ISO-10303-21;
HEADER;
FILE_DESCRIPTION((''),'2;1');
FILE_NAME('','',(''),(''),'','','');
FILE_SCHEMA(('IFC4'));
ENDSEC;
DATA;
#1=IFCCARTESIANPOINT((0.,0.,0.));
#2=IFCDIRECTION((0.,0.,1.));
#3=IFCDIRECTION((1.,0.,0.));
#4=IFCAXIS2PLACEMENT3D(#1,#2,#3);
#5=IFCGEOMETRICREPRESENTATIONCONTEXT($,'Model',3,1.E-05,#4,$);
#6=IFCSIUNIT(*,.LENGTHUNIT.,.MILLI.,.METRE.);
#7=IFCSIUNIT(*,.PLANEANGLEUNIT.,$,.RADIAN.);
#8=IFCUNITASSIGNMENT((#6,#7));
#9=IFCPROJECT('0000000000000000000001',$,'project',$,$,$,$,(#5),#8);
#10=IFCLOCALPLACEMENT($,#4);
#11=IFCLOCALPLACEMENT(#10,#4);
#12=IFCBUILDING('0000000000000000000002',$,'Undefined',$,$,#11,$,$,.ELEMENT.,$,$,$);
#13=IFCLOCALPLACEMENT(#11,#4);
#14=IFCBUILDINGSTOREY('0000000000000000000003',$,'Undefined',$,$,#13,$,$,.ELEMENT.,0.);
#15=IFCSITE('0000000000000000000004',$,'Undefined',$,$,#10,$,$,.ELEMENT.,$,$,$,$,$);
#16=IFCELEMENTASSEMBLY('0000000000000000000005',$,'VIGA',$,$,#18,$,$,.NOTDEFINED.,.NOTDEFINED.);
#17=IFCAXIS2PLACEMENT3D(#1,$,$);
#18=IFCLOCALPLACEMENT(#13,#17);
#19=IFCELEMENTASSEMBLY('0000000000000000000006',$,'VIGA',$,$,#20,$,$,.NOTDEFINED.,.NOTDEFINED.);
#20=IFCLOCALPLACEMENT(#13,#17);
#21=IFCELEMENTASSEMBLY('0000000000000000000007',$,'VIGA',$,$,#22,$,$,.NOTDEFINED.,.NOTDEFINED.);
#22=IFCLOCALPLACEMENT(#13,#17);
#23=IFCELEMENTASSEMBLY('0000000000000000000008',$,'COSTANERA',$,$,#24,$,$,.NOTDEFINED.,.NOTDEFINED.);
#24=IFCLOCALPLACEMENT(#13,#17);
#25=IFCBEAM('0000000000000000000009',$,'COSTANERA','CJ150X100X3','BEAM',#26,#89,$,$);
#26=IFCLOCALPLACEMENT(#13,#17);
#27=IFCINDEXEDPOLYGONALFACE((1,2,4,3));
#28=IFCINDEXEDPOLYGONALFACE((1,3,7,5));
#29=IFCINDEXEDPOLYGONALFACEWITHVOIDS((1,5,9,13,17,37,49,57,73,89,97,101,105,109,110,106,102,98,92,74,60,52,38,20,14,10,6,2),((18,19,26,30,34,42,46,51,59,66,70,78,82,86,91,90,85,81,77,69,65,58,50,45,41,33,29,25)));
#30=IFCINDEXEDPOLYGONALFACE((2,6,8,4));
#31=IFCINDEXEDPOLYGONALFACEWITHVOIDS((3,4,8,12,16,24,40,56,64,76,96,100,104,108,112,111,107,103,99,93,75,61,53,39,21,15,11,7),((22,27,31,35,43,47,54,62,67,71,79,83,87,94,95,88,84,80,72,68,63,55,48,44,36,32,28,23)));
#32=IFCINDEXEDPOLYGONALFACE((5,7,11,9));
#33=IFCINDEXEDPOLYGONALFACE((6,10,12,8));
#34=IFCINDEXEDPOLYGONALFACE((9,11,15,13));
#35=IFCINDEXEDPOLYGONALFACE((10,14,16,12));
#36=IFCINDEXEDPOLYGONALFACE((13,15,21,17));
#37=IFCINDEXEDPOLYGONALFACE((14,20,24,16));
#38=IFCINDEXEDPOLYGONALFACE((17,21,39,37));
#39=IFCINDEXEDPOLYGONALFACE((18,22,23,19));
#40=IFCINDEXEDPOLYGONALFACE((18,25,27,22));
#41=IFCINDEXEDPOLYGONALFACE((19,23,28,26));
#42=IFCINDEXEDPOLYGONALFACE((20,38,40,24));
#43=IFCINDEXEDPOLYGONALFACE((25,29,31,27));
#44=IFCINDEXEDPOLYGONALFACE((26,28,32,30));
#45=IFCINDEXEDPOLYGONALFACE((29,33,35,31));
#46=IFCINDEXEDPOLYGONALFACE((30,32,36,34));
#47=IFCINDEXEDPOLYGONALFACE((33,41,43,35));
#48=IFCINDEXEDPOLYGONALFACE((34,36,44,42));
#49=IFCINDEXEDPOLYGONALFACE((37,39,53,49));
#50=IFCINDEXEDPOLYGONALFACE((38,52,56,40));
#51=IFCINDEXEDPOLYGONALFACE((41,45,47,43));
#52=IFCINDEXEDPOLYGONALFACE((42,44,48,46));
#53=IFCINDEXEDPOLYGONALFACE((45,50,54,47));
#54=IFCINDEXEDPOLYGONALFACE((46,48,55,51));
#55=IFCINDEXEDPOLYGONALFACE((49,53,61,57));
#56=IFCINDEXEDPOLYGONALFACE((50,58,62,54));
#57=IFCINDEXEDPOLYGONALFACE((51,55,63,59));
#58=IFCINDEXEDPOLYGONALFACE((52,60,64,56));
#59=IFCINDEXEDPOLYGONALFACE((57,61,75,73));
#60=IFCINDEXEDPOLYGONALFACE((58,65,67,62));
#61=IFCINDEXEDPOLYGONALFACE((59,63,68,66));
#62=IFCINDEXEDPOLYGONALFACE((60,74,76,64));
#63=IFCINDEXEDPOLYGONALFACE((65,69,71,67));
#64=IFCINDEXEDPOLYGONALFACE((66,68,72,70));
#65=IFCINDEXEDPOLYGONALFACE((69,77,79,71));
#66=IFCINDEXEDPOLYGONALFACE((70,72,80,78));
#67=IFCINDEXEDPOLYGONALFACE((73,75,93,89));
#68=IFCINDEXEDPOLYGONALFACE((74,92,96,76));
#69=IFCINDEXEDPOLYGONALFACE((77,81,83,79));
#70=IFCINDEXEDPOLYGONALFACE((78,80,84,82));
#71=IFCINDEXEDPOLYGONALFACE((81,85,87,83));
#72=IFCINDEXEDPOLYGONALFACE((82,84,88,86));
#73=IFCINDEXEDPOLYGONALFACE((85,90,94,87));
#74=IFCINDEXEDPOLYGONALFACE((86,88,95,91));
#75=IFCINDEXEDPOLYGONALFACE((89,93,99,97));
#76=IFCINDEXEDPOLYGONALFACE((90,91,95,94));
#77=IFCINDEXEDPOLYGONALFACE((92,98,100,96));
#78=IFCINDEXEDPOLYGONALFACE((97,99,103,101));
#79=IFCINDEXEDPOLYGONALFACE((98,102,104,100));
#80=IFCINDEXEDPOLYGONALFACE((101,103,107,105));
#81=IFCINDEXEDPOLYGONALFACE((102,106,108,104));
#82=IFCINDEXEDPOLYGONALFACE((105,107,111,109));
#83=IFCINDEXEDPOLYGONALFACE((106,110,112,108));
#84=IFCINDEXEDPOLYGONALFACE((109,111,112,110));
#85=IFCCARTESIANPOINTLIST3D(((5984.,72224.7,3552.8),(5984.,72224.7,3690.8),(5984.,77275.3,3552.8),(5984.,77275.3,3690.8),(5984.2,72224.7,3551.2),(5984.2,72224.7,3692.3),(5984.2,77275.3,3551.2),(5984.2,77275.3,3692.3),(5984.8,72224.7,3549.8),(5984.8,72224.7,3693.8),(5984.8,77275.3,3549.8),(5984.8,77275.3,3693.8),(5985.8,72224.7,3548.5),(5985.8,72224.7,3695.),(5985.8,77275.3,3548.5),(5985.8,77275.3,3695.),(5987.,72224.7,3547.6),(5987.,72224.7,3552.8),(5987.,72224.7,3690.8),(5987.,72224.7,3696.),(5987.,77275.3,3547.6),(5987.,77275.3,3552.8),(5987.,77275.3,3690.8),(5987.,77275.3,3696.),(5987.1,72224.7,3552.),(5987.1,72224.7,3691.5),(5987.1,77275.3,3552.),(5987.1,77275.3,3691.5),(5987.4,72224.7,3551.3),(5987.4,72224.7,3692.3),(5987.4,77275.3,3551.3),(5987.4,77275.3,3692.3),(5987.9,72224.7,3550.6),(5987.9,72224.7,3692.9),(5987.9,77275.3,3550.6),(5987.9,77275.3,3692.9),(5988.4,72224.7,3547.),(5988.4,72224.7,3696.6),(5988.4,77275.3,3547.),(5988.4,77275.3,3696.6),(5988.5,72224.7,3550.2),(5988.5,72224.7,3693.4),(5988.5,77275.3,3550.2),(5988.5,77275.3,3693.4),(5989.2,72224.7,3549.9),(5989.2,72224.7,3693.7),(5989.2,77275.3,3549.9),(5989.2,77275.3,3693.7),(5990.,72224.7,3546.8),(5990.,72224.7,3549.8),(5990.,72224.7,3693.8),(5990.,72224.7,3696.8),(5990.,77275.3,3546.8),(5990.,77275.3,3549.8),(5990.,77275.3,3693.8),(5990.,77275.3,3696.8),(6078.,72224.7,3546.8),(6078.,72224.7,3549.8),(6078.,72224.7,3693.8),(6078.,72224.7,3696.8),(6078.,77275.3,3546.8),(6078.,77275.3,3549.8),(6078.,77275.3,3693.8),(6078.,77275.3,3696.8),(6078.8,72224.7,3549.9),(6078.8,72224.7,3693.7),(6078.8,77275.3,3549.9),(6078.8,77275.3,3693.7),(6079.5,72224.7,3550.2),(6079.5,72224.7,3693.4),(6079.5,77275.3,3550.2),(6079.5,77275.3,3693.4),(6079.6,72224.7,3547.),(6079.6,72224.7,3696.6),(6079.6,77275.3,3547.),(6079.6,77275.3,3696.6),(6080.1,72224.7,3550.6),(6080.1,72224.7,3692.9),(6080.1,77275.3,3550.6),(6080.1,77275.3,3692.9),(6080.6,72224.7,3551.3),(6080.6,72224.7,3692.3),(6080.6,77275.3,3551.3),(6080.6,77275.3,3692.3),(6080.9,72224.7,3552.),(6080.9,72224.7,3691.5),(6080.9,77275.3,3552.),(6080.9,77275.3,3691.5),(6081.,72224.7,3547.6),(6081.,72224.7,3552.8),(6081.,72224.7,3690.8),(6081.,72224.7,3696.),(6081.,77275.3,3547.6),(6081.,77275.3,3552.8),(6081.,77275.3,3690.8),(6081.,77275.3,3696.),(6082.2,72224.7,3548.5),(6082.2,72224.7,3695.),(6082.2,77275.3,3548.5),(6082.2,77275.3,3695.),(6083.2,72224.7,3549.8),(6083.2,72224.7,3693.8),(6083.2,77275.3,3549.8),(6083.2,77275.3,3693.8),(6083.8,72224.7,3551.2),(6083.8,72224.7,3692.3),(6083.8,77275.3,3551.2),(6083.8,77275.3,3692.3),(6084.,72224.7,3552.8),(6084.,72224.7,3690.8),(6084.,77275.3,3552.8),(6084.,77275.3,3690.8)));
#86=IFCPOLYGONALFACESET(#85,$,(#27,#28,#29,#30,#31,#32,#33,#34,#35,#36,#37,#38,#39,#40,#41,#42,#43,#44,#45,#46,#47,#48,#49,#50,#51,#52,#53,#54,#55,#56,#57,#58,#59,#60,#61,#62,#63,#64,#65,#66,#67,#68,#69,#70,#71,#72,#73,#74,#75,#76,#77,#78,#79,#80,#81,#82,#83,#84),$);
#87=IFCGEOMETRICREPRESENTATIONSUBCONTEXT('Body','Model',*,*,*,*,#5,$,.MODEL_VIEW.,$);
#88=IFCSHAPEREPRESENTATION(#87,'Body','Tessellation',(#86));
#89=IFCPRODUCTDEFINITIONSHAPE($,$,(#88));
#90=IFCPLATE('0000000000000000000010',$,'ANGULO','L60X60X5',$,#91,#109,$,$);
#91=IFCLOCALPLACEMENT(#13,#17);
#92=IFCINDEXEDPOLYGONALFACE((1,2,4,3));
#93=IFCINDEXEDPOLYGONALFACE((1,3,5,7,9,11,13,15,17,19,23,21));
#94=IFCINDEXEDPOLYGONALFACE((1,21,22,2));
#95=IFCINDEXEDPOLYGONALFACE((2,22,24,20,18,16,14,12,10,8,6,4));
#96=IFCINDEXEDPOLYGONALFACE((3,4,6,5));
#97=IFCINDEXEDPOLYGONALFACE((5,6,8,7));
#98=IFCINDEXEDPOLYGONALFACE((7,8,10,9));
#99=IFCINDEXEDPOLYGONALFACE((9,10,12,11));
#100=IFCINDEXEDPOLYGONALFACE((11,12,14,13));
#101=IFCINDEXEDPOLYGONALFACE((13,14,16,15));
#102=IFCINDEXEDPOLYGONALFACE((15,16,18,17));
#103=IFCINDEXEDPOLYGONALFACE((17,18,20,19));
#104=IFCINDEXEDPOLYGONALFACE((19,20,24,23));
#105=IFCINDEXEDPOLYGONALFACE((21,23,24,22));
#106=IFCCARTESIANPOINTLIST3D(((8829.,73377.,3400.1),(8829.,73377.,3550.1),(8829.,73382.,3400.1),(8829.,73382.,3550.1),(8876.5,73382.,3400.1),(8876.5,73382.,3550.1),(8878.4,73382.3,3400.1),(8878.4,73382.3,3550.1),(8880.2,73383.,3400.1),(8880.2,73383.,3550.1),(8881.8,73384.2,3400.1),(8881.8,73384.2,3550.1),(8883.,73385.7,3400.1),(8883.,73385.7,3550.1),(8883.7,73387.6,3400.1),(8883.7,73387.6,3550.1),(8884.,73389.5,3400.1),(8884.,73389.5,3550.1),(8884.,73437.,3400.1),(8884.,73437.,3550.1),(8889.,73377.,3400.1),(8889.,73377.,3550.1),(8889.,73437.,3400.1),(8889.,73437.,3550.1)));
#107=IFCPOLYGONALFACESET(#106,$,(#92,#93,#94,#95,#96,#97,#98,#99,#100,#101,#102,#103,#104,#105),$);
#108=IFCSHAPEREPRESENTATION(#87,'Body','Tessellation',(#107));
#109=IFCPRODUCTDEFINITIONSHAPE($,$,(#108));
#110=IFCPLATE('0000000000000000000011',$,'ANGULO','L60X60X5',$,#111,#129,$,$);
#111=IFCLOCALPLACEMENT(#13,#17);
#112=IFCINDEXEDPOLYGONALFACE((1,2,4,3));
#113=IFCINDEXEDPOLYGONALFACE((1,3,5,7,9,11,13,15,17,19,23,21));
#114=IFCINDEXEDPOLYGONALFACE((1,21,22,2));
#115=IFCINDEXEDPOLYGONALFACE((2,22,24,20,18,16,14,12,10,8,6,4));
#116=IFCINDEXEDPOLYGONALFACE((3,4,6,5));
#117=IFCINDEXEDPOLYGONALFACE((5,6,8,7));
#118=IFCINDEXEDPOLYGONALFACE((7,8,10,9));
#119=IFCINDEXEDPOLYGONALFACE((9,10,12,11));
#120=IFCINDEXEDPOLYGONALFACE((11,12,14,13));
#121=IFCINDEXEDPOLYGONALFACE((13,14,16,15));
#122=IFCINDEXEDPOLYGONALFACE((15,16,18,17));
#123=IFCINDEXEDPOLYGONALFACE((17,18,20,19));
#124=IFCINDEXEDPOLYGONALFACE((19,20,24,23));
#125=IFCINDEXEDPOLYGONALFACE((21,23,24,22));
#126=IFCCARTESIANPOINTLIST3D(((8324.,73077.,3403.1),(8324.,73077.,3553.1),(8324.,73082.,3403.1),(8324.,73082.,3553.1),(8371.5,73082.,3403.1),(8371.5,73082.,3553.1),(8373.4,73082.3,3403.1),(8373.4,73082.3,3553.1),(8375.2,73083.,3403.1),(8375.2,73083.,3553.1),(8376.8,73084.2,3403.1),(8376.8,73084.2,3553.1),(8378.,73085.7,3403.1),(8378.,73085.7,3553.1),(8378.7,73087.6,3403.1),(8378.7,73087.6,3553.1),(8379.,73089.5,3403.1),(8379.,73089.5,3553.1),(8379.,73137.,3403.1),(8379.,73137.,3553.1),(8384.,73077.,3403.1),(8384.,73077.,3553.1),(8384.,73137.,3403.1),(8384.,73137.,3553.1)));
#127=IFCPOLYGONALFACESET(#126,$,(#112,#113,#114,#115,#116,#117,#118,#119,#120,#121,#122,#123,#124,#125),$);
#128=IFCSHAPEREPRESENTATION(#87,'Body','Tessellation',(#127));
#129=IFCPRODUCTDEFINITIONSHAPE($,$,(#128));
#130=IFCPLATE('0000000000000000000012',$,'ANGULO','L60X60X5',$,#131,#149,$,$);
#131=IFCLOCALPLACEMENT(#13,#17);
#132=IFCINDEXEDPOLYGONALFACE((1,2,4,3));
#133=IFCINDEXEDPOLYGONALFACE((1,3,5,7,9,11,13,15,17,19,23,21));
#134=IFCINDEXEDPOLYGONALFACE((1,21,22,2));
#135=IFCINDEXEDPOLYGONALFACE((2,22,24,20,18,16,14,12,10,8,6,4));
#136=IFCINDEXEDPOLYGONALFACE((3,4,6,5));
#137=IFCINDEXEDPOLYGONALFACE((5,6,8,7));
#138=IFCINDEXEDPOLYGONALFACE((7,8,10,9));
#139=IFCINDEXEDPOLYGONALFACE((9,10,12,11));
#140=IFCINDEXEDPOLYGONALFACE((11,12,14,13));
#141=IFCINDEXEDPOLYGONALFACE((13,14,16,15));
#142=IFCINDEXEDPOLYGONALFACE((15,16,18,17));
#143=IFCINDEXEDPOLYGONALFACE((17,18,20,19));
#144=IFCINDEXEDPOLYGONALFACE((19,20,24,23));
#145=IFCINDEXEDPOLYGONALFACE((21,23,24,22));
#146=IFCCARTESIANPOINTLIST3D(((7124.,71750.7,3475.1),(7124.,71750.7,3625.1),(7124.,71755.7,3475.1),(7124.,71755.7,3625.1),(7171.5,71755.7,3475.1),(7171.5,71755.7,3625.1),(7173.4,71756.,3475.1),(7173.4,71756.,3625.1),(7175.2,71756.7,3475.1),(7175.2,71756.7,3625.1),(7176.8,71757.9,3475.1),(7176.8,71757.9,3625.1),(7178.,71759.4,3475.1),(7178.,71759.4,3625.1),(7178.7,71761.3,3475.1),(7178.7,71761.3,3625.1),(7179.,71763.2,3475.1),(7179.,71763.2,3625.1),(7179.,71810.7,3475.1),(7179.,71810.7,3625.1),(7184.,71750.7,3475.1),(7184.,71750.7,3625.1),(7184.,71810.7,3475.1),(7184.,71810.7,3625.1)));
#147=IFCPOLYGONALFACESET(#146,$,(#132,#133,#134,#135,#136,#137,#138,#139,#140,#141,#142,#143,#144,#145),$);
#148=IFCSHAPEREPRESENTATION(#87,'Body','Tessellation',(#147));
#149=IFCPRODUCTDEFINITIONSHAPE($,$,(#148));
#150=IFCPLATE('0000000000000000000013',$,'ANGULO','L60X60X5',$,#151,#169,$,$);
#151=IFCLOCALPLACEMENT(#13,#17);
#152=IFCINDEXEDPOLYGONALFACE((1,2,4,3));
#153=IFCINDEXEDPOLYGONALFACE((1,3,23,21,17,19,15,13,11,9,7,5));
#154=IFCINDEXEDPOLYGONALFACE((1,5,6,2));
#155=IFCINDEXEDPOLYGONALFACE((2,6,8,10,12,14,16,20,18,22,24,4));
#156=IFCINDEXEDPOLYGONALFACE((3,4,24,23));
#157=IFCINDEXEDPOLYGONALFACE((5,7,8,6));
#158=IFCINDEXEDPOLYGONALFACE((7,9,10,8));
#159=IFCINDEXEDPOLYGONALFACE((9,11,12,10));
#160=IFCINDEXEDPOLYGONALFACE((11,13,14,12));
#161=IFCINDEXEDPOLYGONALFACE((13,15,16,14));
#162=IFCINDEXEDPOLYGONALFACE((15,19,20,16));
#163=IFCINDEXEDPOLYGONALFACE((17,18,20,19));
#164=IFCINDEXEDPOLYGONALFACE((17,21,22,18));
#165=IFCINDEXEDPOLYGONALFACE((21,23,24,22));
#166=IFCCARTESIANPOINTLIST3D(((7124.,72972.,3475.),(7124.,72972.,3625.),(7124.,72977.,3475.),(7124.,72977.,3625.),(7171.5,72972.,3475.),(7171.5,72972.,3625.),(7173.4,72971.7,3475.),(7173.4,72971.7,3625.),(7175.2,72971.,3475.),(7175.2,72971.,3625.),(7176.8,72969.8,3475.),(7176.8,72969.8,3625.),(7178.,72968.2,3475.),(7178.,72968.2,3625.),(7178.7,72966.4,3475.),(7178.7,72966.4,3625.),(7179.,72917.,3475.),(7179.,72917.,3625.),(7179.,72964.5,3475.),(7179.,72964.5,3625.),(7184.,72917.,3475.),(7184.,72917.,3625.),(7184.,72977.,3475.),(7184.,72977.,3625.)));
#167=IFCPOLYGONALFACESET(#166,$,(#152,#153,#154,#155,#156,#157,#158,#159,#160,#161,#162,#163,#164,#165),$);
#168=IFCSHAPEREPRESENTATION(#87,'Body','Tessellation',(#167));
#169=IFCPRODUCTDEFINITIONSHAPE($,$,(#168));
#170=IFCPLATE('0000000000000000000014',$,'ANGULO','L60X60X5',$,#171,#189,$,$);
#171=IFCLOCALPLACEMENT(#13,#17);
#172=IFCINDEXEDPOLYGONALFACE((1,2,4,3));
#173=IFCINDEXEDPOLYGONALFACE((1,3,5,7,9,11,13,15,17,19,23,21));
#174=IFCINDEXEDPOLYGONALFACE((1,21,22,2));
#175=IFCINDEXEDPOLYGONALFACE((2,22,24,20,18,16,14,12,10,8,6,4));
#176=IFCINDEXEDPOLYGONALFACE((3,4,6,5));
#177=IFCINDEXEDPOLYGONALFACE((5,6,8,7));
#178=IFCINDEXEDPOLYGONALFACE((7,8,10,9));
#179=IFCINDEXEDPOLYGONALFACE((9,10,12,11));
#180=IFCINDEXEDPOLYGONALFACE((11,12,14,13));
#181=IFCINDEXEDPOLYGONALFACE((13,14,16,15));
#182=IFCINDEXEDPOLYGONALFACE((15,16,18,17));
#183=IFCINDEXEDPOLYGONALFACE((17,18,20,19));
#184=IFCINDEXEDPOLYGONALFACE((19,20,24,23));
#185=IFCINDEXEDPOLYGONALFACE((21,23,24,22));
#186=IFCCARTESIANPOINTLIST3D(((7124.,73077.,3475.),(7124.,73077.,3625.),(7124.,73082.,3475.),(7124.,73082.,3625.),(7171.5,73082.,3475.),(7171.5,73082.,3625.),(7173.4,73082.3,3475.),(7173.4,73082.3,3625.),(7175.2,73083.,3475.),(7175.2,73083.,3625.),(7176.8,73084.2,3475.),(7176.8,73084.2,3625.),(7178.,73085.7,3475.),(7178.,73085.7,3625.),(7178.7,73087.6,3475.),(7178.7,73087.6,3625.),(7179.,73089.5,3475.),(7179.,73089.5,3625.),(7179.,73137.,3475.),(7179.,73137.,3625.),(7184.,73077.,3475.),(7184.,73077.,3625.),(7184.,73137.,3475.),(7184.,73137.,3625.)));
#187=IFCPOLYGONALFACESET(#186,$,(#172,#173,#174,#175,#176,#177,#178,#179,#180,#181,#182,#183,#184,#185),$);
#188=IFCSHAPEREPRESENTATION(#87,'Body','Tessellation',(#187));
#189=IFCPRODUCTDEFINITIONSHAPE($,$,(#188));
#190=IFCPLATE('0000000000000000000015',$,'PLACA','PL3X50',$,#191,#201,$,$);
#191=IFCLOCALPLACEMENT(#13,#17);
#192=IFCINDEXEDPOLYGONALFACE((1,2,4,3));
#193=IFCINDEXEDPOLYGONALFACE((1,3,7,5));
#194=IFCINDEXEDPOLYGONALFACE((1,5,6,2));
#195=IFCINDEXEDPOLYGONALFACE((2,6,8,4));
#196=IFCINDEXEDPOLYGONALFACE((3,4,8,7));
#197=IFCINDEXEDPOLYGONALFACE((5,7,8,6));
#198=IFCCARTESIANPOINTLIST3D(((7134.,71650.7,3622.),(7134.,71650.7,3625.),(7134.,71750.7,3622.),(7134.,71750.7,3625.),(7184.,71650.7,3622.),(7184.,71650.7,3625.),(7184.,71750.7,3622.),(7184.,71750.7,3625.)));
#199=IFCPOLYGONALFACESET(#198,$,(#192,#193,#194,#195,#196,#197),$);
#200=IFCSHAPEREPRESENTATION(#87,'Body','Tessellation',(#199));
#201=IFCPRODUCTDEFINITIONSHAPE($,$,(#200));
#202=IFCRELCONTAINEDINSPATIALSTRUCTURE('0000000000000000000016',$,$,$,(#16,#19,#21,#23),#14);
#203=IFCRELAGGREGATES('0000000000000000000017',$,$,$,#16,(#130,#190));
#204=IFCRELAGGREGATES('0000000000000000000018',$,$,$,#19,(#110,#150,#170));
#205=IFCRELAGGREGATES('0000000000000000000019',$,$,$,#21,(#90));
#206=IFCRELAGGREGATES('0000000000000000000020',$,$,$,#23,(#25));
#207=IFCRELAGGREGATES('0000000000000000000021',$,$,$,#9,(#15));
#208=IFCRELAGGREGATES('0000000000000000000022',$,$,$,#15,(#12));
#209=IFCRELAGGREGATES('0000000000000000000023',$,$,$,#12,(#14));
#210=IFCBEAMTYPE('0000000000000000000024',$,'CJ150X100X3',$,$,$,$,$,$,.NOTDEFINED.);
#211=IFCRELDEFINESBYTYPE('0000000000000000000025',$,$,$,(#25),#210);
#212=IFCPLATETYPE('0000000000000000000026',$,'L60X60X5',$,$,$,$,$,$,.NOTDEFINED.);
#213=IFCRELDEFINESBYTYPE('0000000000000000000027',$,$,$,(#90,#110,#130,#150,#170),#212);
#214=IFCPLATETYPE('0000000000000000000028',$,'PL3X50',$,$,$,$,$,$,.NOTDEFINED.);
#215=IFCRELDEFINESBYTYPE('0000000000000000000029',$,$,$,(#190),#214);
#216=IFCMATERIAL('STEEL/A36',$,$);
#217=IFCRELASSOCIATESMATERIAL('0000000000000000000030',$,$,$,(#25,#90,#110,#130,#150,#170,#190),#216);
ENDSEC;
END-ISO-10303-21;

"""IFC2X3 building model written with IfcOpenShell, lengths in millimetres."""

from ifc_helpers import new_model, si_unit, frame, origin_with_axes, origin_2d_with_axis, place, context, subcontext, project, spatial, polyline, hollow_rectangle, l_section, outline, extrude, material, type_object, element, aggregate, save


model = new_model("IFC2X3")

# Units and contexts
model_context = context("Model", 3, precision=1e-05, world=origin_with_axes())
body_context = subcontext(model_context, "Body", "Model", "MODEL_VIEW")
ifc_project = project(units=[si_unit("LENGTHUNIT", "METRE", prefix="MILLI"), si_unit("PLANEANGLEUNIT", "RADIAN")], contexts=[model_context])

# Site, building, storey
site_placement = place(None, origin_with_axes())
site = spatial("IfcSite", under=ifc_project, at=site_placement, Name="Undefined", CompositionType="ELEMENT")
building_placement = place(site_placement, origin_with_axes())
building = spatial("IfcBuilding", under=site, at=building_placement, Name="Undefined", CompositionType="ELEMENT")
storey_placement = place(building_placement, origin_with_axes())
storey = spatial("IfcBuildingStorey", under=building, at=storey_placement, Name="Undefined", CompositionType="ELEMENT", Elevation=0.0)

# Element assembly
assembly_1_placement = place(storey_placement, origin_with_axes())
assembly_1 = element("IfcElementAssembly", 1, at=assembly_1_placement, inside=storey, Name="VIGA", AssemblyPlace="NOTDEFINED", PredefinedType="NOTDEFINED")
ifc_material_1 = material(Name="STEEL/A36")

# Element assembly
assembly_2_placement = place(storey_placement, origin_with_axes())
assembly_2 = element("IfcElementAssembly", 2, at=assembly_2_placement, inside=storey, Name="VIGA", AssemblyPlace="NOTDEFINED", PredefinedType="NOTDEFINED")

# Element assemblies, beam
assembly_3_placement = place(storey_placement, origin_with_axes())
assembly_3 = element("IfcElementAssembly", 3, at=assembly_3_placement, inside=storey, Name="VIGA", AssemblyPlace="NOTDEFINED", PredefinedType="NOTDEFINED")
assembly_4_placement = place(storey_placement, origin_with_axes())
assembly_4 = element("IfcElementAssembly", 4, at=assembly_4_placement, inside=storey, Name="COSTANERA", AssemblyPlace="NOTDEFINED", PredefinedType="NOTDEFINED")
beam_type_1 = type_object("IfcBeamType", Name="CJ150X100X3", PredefinedType="NOTDEFINED")
beam_1_placement = place(assembly_4_placement, frame((6034.0, 72224.7, 3621.8), z_axis=(0.0, 0.0, 1.0), x_axis=(0.0, 1.0, 0.0)))
beam_1 = element("IfcBeam", 5, at=beam_1_placement, type_object=beam_type_1, material=ifc_material_1, Name="COSTANERA", Description="CJ150X100X3", ObjectType="BEAM", context=body_context, shape_type="SweptSolid", body=[
    extrude(hollow_rectangle(XDim=100.0, YDim=150.0, WallThickness=3.0, InnerFilletRadius=3.0, OuterFilletRadius=6.0, at=origin_2d_with_axis()), frame((5050.6, 0.0, 0.0), z_axis=(-1.0, 0.0, 0.0), x_axis=(0.0, -1.0, 0.0)), (0.0, 0.0, 1.0), 5050.6),
])

# Plates
plate_type_1 = type_object("IfcPlateType", Name="L60X60X5", PredefinedType="NOTDEFINED")
plate_1_placement = place(assembly_3_placement, frame((8859.0, 73407.0, 3550.1), z_axis=(-1.0, 0.0, 0.0), x_axis=(0.0, 0.0, -1.0)))
plate_1 = element("IfcPlate", 6, at=plate_1_placement, type_object=plate_type_1, material=ifc_material_1, Name="ANGULO", Description="L60X60X5", context=body_context, shape_type="SweptSolid", body=[
    extrude(l_section(Depth=60.0, Width=60.0, Thickness=5.0, FilletRadius=7.5, at=origin_2d_with_axis()), frame((150.0, 0.0, 0.0), z_axis=(-1.0, 0.0, 0.0), x_axis=(0.0, -1.0, 0.0)), (0.0, 0.0, 1.0), 150.0),
])
plate_2_placement = place(assembly_2_placement, frame((8354.0, 73107.0, 3553.1), z_axis=(-1.0, 0.0, 0.0), x_axis=(0.0, 0.0, -1.0)))
plate_2 = element("IfcPlate", 7, at=plate_2_placement, type_object=plate_type_1, material=ifc_material_1, Name="ANGULO", Description="L60X60X5", context=body_context, shape_type="SweptSolid", body=[
    extrude(l_section(Depth=60.0, Width=60.0, Thickness=5.0, FilletRadius=7.5, at=origin_2d_with_axis()), frame((150.0, 0.0, 0.0), z_axis=(-1.0, 0.0, 0.0), x_axis=(0.0, -1.0, 0.0)), (0.0, 0.0, 1.0), 150.0),
])
plate_3_placement = place(assembly_1_placement, frame((7154.0, 71780.7, 3625.1), z_axis=(-1.0, 0.0, 0.0), x_axis=(0.0, 0.0, -1.0)))
plate_3 = element("IfcPlate", 8, at=plate_3_placement, type_object=plate_type_1, material=ifc_material_1, Name="ANGULO", Description="L60X60X5", context=body_context, shape_type="SweptSolid", body=[
    extrude(l_section(Depth=60.0, Width=60.0, Thickness=5.0, FilletRadius=7.5, at=origin_2d_with_axis()), frame((150.0, 0.0, 0.0), z_axis=(-1.0, 0.0, 0.0), x_axis=(0.0, -1.0, 0.0)), (0.0, 0.0, 1.0), 150.0),
])
plate_4_placement = place(assembly_2_placement, frame((7154.0, 72947.0, 3475.0), z_axis=(-1.0, 0.0, 0.0), x_axis=(0.0, 0.0, 1.0)))
plate_4 = element("IfcPlate", 9, at=plate_4_placement, type_object=plate_type_1, material=ifc_material_1, Name="ANGULO", Description="L60X60X5", context=body_context, shape_type="SweptSolid", body=[
    extrude(l_section(Depth=60.0, Width=60.0, Thickness=5.0, FilletRadius=7.5, at=origin_2d_with_axis()), frame((150.0, 0.0, 0.0), z_axis=(-1.0, 0.0, 0.0), x_axis=(0.0, -1.0, 0.0)), (0.0, 0.0, 1.0), 150.0),
])
plate_5_placement = place(assembly_2_placement, frame((7154.0, 73107.0, 3625.0), z_axis=(-1.0, 0.0, 0.0), x_axis=(0.0, 0.0, -1.0)))
plate_5 = element("IfcPlate", 10, at=plate_5_placement, type_object=plate_type_1, material=ifc_material_1, Name="ANGULO", Description="L60X60X5", context=body_context, shape_type="SweptSolid", body=[
    extrude(l_section(Depth=60.0, Width=60.0, Thickness=5.0, FilletRadius=7.5, at=origin_2d_with_axis()), frame((150.0, 0.0, 0.0), z_axis=(-1.0, 0.0, 0.0), x_axis=(0.0, -1.0, 0.0)), (0.0, 0.0, 1.0), 150.0),
])
plate_type_2 = type_object("IfcPlateType", Name="PL3X50", PredefinedType="NOTDEFINED")
plate_6_placement = place(assembly_1_placement, frame((7134.0, 71750.7, 3623.5), z_axis=(0.0, 0.0, -1.0), x_axis=(1.0, 0.0, 0.0)))
plate_6 = element("IfcPlate", 11, at=plate_6_placement, type_object=plate_type_2, material=ifc_material_1, Name="PLACA", Description="PL3X50", context=body_context, shape_type="SweptSolid", body=[
    extrude(outline(polyline([(0.0, 0.0), (50.0, 0.0), (50.0, 100.0), (0.0, 100.0), (0.0, 0.0)])), frame((0.0, 0.0, -1.5), z_axis=(0.0, 0.0, 1.0), x_axis=(1.0, 0.0, 0.0)), (0.0, 0.0, 1.0), 3.0),
])
aggregate(assembly_1, [plate_3, plate_6])

aggregate(assembly_2, [plate_2, plate_4, plate_5])
aggregate(assembly_3, [plate_1])

aggregate(assembly_4, [beam_1])

save(model, "model.ifc")
